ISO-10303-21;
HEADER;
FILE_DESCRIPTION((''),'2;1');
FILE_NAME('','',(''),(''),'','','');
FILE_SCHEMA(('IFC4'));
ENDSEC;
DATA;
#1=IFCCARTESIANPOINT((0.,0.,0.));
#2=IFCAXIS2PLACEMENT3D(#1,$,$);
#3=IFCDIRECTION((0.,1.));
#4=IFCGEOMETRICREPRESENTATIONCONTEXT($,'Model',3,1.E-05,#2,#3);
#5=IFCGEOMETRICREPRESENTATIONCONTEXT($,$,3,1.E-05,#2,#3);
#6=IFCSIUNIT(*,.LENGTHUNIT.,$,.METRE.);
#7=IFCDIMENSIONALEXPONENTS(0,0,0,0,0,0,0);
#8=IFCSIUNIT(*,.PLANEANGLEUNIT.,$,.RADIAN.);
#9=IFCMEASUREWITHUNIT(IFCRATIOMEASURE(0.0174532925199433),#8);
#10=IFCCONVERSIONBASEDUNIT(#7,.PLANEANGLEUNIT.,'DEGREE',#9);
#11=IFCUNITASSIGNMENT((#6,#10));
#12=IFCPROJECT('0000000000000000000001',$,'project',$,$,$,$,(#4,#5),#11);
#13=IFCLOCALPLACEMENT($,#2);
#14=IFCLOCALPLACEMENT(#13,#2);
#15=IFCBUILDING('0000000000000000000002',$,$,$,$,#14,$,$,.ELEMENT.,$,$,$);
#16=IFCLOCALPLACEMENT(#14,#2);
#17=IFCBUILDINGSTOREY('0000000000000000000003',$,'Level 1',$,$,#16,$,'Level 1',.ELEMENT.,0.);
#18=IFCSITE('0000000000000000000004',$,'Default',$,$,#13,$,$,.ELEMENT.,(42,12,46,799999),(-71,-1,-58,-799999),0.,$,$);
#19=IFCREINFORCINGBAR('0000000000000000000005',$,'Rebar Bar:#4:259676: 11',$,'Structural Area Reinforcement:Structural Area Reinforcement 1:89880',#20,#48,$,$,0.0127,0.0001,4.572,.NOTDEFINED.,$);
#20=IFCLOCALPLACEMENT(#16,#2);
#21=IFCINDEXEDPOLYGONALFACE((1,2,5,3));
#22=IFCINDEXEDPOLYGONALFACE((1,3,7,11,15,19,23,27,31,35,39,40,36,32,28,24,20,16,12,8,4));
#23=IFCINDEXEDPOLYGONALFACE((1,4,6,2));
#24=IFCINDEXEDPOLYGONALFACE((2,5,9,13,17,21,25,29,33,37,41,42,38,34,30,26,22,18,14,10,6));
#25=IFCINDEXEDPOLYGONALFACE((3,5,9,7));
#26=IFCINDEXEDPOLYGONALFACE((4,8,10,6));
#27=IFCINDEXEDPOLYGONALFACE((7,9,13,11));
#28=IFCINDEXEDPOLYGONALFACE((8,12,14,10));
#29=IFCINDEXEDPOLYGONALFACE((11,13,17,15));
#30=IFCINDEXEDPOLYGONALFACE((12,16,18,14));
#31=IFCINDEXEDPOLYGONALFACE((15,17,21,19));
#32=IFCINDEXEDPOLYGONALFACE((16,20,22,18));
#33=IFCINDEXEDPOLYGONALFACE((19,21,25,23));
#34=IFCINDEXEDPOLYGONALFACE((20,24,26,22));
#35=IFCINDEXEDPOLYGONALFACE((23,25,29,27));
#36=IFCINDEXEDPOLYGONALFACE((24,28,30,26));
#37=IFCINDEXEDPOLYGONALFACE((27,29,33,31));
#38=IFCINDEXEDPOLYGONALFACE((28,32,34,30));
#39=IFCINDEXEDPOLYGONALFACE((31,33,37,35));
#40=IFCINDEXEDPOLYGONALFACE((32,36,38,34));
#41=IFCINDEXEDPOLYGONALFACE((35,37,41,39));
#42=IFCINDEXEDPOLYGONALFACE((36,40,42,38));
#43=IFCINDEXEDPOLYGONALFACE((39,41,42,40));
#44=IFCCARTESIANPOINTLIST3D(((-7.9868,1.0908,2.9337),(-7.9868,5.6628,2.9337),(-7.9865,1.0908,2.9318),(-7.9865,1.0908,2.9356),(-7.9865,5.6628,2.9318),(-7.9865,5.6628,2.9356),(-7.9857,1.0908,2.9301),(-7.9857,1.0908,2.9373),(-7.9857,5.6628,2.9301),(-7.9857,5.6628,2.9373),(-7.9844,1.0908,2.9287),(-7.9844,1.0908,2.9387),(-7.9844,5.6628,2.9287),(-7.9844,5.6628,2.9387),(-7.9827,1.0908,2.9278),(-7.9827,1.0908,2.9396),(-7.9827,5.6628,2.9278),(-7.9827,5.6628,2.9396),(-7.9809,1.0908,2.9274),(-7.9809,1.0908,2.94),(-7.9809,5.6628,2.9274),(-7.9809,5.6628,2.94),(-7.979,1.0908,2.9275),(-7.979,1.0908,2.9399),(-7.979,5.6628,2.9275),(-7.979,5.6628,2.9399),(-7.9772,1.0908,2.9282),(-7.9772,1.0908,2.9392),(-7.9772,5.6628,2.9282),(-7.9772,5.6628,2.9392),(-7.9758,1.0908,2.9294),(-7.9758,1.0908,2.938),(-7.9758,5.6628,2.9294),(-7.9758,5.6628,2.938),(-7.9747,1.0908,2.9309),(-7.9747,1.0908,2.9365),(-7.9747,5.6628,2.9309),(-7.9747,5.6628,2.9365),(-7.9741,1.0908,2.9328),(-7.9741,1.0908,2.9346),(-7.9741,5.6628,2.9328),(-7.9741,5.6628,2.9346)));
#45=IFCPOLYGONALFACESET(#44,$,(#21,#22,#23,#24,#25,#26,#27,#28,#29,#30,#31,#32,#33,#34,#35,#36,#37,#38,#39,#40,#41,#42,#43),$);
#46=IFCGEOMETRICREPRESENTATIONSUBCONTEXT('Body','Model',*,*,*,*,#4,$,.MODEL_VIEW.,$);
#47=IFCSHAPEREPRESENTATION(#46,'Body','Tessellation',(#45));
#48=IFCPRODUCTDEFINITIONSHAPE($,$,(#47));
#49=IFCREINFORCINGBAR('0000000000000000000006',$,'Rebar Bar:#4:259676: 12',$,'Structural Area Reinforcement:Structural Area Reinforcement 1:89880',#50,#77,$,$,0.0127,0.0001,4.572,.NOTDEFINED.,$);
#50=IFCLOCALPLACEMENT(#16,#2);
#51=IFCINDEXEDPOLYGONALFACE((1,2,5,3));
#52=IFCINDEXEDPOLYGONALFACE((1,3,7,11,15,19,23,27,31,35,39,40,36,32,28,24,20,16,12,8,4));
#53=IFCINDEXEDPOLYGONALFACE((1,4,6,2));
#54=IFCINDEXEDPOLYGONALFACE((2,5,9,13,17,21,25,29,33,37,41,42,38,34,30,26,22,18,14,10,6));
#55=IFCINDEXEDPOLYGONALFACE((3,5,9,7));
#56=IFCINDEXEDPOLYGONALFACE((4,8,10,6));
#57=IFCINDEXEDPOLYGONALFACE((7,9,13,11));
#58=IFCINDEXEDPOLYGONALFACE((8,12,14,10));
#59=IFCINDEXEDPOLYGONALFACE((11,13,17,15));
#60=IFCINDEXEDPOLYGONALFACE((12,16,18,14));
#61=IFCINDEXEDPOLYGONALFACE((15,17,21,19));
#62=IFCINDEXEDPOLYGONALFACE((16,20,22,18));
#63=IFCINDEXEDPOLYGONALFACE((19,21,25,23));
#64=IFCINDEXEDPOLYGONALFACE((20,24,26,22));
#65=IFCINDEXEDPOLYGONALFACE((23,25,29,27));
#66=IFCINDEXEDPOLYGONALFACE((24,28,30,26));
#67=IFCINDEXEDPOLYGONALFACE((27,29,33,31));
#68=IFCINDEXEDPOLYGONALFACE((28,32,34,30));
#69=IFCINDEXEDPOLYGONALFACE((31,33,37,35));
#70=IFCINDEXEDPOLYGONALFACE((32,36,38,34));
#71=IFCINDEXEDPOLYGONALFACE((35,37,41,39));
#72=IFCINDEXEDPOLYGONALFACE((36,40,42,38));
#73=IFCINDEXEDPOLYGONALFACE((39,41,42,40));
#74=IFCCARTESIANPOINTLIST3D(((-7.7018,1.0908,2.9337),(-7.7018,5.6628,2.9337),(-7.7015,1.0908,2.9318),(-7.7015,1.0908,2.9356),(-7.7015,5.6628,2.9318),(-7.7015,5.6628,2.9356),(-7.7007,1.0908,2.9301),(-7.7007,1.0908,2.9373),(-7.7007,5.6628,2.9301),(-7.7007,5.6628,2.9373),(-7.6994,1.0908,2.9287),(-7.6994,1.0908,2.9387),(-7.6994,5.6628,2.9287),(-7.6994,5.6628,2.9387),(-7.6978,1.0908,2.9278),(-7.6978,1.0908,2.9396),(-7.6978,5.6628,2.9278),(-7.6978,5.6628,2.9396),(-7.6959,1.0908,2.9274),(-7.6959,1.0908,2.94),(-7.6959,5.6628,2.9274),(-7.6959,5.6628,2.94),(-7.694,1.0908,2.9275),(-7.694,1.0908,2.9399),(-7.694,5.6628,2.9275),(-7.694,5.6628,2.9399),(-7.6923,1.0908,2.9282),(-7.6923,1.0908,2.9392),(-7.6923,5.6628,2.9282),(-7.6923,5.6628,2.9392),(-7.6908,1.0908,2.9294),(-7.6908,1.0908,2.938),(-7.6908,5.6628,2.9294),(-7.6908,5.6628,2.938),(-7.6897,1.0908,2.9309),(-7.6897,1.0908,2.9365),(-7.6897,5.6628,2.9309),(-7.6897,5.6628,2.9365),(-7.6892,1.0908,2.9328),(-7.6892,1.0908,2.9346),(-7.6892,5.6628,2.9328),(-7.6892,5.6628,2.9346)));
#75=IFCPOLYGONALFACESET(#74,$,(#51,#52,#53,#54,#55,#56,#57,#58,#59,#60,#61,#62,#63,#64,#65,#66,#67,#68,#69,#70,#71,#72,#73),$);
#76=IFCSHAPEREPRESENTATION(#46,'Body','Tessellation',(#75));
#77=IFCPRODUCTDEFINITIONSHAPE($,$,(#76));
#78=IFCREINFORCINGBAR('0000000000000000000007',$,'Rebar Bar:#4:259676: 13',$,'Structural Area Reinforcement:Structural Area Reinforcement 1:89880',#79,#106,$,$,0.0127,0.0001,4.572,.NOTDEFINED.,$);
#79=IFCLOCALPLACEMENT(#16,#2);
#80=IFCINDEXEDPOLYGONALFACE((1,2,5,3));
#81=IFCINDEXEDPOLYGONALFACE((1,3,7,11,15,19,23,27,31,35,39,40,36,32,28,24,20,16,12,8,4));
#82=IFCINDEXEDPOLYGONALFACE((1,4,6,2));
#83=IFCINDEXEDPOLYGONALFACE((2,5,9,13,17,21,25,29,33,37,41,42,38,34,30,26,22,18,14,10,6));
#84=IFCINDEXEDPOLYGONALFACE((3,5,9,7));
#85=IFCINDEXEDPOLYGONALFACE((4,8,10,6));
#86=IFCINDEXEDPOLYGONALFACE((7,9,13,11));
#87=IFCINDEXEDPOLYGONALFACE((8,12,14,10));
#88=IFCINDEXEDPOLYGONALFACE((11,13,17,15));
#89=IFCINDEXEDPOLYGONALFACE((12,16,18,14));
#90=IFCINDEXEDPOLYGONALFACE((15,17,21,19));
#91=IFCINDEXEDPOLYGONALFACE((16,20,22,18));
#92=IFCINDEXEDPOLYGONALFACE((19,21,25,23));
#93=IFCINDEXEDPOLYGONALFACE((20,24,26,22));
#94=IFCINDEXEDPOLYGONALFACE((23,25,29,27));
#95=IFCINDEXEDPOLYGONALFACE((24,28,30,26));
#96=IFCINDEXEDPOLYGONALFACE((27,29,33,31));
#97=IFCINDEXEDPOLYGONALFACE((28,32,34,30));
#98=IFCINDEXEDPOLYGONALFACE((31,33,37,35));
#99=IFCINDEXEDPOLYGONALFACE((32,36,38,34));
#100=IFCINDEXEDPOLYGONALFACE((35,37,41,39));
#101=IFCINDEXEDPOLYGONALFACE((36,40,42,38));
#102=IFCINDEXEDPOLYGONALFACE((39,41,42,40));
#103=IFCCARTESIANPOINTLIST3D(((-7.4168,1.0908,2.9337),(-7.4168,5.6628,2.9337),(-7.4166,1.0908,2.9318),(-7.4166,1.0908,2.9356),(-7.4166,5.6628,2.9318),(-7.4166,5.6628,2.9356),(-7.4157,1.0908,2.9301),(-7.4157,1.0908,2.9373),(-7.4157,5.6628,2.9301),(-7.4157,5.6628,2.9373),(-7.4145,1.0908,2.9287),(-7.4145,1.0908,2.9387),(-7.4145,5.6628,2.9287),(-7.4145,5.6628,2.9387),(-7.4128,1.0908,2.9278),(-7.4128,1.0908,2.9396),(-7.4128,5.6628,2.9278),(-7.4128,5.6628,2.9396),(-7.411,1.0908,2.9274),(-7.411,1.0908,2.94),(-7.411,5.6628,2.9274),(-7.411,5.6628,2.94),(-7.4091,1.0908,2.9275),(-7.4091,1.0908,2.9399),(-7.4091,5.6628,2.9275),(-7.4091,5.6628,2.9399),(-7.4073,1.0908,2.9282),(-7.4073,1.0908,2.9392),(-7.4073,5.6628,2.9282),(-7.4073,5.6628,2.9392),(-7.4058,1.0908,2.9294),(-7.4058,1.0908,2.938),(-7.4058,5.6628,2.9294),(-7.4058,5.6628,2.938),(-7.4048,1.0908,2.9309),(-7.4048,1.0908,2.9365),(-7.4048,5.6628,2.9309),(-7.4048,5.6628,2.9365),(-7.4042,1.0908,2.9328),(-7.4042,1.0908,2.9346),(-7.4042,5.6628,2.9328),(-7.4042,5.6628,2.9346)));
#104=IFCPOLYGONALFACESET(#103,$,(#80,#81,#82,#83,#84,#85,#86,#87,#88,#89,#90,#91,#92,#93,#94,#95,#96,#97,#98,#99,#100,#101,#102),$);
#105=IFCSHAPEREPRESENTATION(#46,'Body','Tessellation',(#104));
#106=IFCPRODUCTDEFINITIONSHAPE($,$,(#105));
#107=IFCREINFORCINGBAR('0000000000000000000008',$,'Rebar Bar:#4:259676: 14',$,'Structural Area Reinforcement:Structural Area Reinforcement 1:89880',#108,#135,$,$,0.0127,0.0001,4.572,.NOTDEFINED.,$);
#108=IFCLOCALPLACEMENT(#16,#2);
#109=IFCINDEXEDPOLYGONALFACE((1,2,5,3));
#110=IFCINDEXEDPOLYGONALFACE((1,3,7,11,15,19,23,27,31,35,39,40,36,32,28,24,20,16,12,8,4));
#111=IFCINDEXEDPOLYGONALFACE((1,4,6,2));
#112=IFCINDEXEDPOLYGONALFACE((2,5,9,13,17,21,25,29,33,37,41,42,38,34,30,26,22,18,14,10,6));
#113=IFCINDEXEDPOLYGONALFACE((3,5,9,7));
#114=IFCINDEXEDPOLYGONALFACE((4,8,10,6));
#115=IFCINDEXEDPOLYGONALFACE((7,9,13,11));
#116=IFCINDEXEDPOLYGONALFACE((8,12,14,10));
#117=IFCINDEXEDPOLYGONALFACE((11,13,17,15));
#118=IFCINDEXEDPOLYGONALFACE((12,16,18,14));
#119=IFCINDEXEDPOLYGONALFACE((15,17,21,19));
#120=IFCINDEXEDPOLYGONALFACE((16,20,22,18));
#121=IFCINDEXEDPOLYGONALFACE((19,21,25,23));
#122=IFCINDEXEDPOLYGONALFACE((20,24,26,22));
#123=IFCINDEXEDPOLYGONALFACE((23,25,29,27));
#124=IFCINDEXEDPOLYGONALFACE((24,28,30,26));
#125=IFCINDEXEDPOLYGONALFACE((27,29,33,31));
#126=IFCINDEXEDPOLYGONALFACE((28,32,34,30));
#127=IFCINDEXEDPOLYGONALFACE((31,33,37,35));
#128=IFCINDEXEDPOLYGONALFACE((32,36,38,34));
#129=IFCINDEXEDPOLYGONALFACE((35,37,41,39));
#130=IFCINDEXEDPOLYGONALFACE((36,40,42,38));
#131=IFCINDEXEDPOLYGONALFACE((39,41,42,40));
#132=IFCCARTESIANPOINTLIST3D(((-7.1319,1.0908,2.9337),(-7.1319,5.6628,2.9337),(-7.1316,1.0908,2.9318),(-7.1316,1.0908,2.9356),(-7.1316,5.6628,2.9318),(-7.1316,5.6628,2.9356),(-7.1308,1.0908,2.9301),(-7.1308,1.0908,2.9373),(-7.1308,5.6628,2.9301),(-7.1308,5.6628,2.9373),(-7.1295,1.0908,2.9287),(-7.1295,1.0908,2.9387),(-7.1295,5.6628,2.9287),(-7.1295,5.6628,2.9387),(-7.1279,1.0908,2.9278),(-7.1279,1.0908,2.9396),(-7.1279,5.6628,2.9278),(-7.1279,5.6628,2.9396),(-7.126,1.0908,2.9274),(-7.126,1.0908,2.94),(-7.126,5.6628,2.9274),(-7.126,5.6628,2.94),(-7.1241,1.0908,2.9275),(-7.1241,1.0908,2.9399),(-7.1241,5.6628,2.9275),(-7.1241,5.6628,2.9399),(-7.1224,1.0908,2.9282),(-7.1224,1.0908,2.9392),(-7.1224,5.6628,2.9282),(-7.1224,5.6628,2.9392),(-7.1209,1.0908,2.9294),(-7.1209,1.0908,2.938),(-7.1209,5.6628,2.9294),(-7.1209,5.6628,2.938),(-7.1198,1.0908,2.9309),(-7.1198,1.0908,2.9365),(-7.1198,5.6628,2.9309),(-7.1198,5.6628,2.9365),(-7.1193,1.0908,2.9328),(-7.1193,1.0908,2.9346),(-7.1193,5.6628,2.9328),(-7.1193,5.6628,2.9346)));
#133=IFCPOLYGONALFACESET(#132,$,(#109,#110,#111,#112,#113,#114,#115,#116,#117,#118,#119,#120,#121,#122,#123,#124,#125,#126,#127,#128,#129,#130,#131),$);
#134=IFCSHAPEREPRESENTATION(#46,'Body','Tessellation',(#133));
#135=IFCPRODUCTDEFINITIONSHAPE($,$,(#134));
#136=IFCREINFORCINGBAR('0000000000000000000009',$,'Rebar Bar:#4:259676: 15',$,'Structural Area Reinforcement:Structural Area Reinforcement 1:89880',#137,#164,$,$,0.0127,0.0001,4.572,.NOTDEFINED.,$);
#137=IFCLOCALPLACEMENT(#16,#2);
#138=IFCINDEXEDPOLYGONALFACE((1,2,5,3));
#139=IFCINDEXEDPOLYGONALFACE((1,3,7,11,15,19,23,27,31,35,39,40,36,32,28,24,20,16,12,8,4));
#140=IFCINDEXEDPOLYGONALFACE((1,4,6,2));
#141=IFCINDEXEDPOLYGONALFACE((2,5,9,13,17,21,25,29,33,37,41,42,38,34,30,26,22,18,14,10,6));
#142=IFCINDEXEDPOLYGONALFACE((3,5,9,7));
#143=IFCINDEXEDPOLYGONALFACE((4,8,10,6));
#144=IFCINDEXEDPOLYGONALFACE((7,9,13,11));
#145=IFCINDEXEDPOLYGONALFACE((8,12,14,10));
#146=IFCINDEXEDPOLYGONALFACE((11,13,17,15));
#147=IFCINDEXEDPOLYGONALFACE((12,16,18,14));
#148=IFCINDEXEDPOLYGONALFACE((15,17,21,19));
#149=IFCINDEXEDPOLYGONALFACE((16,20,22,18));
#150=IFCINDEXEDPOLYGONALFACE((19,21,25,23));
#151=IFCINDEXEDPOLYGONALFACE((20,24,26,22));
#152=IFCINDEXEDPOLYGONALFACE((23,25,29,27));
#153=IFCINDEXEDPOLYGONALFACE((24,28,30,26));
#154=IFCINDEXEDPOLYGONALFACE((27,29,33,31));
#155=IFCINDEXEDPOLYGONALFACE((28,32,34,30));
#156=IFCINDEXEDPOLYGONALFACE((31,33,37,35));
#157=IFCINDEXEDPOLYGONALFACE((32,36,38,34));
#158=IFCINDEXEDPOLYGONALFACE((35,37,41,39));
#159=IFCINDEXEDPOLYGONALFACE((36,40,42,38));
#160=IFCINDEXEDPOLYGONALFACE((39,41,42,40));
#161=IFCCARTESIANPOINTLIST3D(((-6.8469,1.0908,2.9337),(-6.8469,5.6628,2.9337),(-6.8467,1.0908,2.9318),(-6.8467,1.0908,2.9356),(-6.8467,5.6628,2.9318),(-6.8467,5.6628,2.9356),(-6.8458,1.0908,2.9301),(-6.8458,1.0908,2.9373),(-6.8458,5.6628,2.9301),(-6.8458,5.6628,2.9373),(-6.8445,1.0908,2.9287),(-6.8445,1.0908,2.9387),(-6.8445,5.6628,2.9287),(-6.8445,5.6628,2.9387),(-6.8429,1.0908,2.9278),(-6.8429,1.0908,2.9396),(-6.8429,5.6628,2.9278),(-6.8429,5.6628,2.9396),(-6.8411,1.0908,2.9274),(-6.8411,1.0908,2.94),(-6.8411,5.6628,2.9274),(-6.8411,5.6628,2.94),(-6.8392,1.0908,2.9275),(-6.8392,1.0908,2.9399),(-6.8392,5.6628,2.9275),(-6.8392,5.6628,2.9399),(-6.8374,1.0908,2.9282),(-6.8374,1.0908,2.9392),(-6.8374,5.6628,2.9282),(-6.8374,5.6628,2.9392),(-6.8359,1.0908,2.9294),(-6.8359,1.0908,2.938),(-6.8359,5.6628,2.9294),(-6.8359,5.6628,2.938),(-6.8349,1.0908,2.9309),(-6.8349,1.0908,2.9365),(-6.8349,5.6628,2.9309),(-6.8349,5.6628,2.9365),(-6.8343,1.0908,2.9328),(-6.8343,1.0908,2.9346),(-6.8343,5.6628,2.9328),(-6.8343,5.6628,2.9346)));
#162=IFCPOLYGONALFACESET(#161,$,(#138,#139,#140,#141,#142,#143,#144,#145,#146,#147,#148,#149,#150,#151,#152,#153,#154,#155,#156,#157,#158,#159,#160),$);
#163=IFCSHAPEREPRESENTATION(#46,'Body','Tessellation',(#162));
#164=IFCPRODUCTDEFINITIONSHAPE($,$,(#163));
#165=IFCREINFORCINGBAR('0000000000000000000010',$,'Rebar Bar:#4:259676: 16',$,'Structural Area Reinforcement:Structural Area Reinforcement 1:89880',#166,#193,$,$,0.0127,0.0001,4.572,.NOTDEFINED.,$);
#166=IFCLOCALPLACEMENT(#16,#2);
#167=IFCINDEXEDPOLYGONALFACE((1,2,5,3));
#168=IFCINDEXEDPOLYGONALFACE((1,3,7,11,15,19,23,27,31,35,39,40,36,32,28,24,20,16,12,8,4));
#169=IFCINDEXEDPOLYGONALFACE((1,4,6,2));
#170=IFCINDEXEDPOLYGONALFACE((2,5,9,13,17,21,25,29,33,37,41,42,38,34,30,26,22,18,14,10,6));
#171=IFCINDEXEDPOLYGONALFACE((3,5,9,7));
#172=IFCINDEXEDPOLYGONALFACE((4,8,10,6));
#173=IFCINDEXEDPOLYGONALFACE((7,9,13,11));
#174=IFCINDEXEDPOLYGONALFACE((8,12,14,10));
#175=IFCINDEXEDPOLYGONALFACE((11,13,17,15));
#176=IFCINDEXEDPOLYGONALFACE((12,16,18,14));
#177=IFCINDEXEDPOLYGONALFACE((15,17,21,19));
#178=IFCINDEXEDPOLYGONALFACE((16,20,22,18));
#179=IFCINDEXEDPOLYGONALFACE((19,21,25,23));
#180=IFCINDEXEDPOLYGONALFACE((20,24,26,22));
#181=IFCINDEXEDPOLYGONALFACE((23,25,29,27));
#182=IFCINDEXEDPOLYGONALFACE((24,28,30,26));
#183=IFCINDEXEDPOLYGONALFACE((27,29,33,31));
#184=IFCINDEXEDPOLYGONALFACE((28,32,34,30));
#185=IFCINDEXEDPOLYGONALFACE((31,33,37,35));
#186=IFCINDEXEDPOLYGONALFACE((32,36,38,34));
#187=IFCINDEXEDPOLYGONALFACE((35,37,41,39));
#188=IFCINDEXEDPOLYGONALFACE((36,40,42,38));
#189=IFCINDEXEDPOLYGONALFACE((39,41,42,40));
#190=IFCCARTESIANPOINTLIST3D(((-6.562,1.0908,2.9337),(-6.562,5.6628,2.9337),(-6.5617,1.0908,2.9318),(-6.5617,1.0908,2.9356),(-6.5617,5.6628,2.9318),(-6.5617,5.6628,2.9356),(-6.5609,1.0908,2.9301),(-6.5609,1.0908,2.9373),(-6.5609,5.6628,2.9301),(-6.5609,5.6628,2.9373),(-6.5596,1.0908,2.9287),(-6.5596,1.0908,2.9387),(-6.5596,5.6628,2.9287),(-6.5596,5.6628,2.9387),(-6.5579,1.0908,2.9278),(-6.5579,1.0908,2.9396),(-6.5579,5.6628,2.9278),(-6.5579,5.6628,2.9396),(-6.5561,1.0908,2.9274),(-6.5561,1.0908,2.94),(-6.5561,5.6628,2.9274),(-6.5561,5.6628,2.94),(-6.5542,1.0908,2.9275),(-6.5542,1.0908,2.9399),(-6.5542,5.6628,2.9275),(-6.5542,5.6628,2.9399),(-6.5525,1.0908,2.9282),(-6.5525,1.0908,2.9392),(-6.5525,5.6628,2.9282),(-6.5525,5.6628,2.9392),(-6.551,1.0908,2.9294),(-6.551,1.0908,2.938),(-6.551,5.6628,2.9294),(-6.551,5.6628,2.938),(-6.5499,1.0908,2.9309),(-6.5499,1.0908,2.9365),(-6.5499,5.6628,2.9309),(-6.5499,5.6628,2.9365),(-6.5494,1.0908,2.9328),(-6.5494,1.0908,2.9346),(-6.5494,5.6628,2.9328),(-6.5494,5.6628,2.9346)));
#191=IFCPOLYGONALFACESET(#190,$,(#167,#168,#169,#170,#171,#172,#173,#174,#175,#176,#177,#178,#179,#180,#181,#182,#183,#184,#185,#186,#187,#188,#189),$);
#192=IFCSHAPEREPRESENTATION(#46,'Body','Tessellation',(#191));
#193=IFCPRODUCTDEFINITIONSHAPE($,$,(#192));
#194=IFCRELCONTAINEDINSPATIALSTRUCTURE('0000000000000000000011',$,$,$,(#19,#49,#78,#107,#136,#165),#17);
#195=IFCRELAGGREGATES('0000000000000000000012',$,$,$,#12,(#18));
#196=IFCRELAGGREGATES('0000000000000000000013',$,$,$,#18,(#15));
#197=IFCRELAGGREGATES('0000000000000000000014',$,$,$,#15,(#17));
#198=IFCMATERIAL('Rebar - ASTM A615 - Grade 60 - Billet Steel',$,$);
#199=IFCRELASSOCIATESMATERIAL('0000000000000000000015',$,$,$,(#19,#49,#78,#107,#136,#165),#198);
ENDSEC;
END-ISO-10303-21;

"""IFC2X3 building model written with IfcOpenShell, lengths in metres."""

from ifc_helpers import new_model, entity, si_unit, converted_unit, direction, origin, place, context, subcontext, project, spatial, material, element, save


model = new_model("IFC2X3")

# Units and contexts
model_context = context("Model", 3, precision=1e-05, world=origin(), true_north=direction((0.0, 1.0)))
context_of_model = context(None, 3, precision=1e-05, world=origin(), true_north=direction((0.0, 1.0)))
body_context = subcontext(model_context, "Body", "Model", "MODEL_VIEW")
ifc_project = project(units=[si_unit("LENGTHUNIT", "METRE"), converted_unit("PLANEANGLEUNIT", "DEGREE", entity("IfcRatioMeasure", 0.0174532925199433), si_unit("PLANEANGLEUNIT", "RADIAN"), dimensions=[0, 0, 0, 0, 0, 0, 0])], contexts=[model_context, context_of_model])

# Site, building, storey
site_placement = place(None, origin())
site = spatial("IfcSite", under=ifc_project, at=site_placement, Name="Default", CompositionType="ELEMENT", RefLatitude=(42, 12, 46, 799999), RefLongitude=(-71, -1, -58, -799999), RefElevation=0.0)
building_placement = place(site_placement, origin())
building = spatial("IfcBuilding", under=site, at=building_placement, CompositionType="ELEMENT")
storey_placement = place(building_placement, origin())
storey = spatial("IfcBuildingStorey", under=building, at=storey_placement, Name="Level 1", LongName="Level 1", CompositionType="ELEMENT", Elevation=0.0)

# Reinforcing bars
ifc_material_1 = material(Name="Rebar - ASTM A615 - Grade 60 - Billet Steel")
reinforcing_bar_1_placement = place(storey_placement, origin())
element("IfcReinforcingBar", 1, at=reinforcing_bar_1_placement, inside=storey, material=ifc_material_1, Name="Rebar Bar:#4:259676: 11", ObjectType="Structural Area Reinforcement:Structural Area Reinforcement 1:89880", BarLength=4.572, BarRole="NOTDEFINED", CrossSectionArea=0.0001, NominalDiameter=0.0127, context=body_context, shape_type="AdvancedSweptSolid", body=[
    entity("IfcSweptDiskSolid", entity("IfcCompositeCurve", [entity("IfcCompositeCurveSegment", "CONTINUOUS", True, entity("IfcPolyline", [entity("IfcCartesianPoint", [-7.9804, 5.6628, 2.9337]), entity("IfcCartesianPoint", [-7.9804, 1.0908, 2.9337])]))], False), 0.0063, None, 0.0, 1.0),
])
reinforcing_bar_2_placement = place(storey_placement, origin())
element("IfcReinforcingBar", 2, at=reinforcing_bar_2_placement, inside=storey, material=ifc_material_1, Name="Rebar Bar:#4:259676: 12", ObjectType="Structural Area Reinforcement:Structural Area Reinforcement 1:89880", BarLength=4.572, BarRole="NOTDEFINED", CrossSectionArea=0.0001, NominalDiameter=0.0127, context=body_context, shape_type="AdvancedSweptSolid", body=[
    entity("IfcSweptDiskSolid", entity("IfcCompositeCurve", [entity("IfcCompositeCurveSegment", "CONTINUOUS", True, entity("IfcPolyline", [entity("IfcCartesianPoint", [-7.6955, 5.6628, 2.9337]), entity("IfcCartesianPoint", [-7.6955, 1.0908, 2.9337])]))], False), 0.0063, None, 0.0, 1.0),
])
reinforcing_bar_3_placement = place(storey_placement, origin())
element("IfcReinforcingBar", 3, at=reinforcing_bar_3_placement, inside=storey, material=ifc_material_1, Name="Rebar Bar:#4:259676: 13", ObjectType="Structural Area Reinforcement:Structural Area Reinforcement 1:89880", BarLength=4.572, BarRole="NOTDEFINED", CrossSectionArea=0.0001, NominalDiameter=0.0127, context=body_context, shape_type="AdvancedSweptSolid", body=[
    entity("IfcSweptDiskSolid", entity("IfcCompositeCurve", [entity("IfcCompositeCurveSegment", "CONTINUOUS", True, entity("IfcPolyline", [entity("IfcCartesianPoint", [-7.4105, 5.6628, 2.9337]), entity("IfcCartesianPoint", [-7.4105, 1.0908, 2.9337])]))], False), 0.0063, None, 0.0, 1.0),
])
reinforcing_bar_4_placement = place(storey_placement, origin())
element("IfcReinforcingBar", 4, at=reinforcing_bar_4_placement, inside=storey, material=ifc_material_1, Name="Rebar Bar:#4:259676: 14", ObjectType="Structural Area Reinforcement:Structural Area Reinforcement 1:89880", BarLength=4.572, BarRole="NOTDEFINED", CrossSectionArea=0.0001, NominalDiameter=0.0127, context=body_context, shape_type="AdvancedSweptSolid", body=[
    entity("IfcSweptDiskSolid", entity("IfcCompositeCurve", [entity("IfcCompositeCurveSegment", "CONTINUOUS", True, entity("IfcPolyline", [entity("IfcCartesianPoint", [-7.1255, 5.6628, 2.9337]), entity("IfcCartesianPoint", [-7.1255, 1.0908, 2.9337])]))], False), 0.0063, None, 0.0, 1.0),
])
reinforcing_bar_5_placement = place(storey_placement, origin())
element("IfcReinforcingBar", 5, at=reinforcing_bar_5_placement, inside=storey, material=ifc_material_1, Name="Rebar Bar:#4:259676: 15", ObjectType="Structural Area Reinforcement:Structural Area Reinforcement 1:89880", BarLength=4.572, BarRole="NOTDEFINED", CrossSectionArea=0.0001, NominalDiameter=0.0127, context=body_context, shape_type="AdvancedSweptSolid", body=[
    entity("IfcSweptDiskSolid", entity("IfcCompositeCurve", [entity("IfcCompositeCurveSegment", "CONTINUOUS", True, entity("IfcPolyline", [entity("IfcCartesianPoint", [-6.8406, 5.6628, 2.9337]), entity("IfcCartesianPoint", [-6.8406, 1.0908, 2.9337])]))], False), 0.0063, None, 0.0, 1.0),
])
reinforcing_bar_6_placement = place(storey_placement, origin())
element("IfcReinforcingBar", 6, at=reinforcing_bar_6_placement, inside=storey, material=ifc_material_1, Name="Rebar Bar:#4:259676: 16", ObjectType="Structural Area Reinforcement:Structural Area Reinforcement 1:89880", BarLength=4.572, BarRole="NOTDEFINED", CrossSectionArea=0.0001, NominalDiameter=0.0127, context=body_context, shape_type="AdvancedSweptSolid", body=[
    entity("IfcSweptDiskSolid", entity("IfcCompositeCurve", [entity("IfcCompositeCurveSegment", "CONTINUOUS", True, entity("IfcPolyline", [entity("IfcCartesianPoint", [-6.5556, 5.6628, 2.9337]), entity("IfcCartesianPoint", [-6.5556, 1.0908, 2.9337])]))], False), 0.0063, None, 0.0, 1.0),
])

save(model, "model.ifc")
